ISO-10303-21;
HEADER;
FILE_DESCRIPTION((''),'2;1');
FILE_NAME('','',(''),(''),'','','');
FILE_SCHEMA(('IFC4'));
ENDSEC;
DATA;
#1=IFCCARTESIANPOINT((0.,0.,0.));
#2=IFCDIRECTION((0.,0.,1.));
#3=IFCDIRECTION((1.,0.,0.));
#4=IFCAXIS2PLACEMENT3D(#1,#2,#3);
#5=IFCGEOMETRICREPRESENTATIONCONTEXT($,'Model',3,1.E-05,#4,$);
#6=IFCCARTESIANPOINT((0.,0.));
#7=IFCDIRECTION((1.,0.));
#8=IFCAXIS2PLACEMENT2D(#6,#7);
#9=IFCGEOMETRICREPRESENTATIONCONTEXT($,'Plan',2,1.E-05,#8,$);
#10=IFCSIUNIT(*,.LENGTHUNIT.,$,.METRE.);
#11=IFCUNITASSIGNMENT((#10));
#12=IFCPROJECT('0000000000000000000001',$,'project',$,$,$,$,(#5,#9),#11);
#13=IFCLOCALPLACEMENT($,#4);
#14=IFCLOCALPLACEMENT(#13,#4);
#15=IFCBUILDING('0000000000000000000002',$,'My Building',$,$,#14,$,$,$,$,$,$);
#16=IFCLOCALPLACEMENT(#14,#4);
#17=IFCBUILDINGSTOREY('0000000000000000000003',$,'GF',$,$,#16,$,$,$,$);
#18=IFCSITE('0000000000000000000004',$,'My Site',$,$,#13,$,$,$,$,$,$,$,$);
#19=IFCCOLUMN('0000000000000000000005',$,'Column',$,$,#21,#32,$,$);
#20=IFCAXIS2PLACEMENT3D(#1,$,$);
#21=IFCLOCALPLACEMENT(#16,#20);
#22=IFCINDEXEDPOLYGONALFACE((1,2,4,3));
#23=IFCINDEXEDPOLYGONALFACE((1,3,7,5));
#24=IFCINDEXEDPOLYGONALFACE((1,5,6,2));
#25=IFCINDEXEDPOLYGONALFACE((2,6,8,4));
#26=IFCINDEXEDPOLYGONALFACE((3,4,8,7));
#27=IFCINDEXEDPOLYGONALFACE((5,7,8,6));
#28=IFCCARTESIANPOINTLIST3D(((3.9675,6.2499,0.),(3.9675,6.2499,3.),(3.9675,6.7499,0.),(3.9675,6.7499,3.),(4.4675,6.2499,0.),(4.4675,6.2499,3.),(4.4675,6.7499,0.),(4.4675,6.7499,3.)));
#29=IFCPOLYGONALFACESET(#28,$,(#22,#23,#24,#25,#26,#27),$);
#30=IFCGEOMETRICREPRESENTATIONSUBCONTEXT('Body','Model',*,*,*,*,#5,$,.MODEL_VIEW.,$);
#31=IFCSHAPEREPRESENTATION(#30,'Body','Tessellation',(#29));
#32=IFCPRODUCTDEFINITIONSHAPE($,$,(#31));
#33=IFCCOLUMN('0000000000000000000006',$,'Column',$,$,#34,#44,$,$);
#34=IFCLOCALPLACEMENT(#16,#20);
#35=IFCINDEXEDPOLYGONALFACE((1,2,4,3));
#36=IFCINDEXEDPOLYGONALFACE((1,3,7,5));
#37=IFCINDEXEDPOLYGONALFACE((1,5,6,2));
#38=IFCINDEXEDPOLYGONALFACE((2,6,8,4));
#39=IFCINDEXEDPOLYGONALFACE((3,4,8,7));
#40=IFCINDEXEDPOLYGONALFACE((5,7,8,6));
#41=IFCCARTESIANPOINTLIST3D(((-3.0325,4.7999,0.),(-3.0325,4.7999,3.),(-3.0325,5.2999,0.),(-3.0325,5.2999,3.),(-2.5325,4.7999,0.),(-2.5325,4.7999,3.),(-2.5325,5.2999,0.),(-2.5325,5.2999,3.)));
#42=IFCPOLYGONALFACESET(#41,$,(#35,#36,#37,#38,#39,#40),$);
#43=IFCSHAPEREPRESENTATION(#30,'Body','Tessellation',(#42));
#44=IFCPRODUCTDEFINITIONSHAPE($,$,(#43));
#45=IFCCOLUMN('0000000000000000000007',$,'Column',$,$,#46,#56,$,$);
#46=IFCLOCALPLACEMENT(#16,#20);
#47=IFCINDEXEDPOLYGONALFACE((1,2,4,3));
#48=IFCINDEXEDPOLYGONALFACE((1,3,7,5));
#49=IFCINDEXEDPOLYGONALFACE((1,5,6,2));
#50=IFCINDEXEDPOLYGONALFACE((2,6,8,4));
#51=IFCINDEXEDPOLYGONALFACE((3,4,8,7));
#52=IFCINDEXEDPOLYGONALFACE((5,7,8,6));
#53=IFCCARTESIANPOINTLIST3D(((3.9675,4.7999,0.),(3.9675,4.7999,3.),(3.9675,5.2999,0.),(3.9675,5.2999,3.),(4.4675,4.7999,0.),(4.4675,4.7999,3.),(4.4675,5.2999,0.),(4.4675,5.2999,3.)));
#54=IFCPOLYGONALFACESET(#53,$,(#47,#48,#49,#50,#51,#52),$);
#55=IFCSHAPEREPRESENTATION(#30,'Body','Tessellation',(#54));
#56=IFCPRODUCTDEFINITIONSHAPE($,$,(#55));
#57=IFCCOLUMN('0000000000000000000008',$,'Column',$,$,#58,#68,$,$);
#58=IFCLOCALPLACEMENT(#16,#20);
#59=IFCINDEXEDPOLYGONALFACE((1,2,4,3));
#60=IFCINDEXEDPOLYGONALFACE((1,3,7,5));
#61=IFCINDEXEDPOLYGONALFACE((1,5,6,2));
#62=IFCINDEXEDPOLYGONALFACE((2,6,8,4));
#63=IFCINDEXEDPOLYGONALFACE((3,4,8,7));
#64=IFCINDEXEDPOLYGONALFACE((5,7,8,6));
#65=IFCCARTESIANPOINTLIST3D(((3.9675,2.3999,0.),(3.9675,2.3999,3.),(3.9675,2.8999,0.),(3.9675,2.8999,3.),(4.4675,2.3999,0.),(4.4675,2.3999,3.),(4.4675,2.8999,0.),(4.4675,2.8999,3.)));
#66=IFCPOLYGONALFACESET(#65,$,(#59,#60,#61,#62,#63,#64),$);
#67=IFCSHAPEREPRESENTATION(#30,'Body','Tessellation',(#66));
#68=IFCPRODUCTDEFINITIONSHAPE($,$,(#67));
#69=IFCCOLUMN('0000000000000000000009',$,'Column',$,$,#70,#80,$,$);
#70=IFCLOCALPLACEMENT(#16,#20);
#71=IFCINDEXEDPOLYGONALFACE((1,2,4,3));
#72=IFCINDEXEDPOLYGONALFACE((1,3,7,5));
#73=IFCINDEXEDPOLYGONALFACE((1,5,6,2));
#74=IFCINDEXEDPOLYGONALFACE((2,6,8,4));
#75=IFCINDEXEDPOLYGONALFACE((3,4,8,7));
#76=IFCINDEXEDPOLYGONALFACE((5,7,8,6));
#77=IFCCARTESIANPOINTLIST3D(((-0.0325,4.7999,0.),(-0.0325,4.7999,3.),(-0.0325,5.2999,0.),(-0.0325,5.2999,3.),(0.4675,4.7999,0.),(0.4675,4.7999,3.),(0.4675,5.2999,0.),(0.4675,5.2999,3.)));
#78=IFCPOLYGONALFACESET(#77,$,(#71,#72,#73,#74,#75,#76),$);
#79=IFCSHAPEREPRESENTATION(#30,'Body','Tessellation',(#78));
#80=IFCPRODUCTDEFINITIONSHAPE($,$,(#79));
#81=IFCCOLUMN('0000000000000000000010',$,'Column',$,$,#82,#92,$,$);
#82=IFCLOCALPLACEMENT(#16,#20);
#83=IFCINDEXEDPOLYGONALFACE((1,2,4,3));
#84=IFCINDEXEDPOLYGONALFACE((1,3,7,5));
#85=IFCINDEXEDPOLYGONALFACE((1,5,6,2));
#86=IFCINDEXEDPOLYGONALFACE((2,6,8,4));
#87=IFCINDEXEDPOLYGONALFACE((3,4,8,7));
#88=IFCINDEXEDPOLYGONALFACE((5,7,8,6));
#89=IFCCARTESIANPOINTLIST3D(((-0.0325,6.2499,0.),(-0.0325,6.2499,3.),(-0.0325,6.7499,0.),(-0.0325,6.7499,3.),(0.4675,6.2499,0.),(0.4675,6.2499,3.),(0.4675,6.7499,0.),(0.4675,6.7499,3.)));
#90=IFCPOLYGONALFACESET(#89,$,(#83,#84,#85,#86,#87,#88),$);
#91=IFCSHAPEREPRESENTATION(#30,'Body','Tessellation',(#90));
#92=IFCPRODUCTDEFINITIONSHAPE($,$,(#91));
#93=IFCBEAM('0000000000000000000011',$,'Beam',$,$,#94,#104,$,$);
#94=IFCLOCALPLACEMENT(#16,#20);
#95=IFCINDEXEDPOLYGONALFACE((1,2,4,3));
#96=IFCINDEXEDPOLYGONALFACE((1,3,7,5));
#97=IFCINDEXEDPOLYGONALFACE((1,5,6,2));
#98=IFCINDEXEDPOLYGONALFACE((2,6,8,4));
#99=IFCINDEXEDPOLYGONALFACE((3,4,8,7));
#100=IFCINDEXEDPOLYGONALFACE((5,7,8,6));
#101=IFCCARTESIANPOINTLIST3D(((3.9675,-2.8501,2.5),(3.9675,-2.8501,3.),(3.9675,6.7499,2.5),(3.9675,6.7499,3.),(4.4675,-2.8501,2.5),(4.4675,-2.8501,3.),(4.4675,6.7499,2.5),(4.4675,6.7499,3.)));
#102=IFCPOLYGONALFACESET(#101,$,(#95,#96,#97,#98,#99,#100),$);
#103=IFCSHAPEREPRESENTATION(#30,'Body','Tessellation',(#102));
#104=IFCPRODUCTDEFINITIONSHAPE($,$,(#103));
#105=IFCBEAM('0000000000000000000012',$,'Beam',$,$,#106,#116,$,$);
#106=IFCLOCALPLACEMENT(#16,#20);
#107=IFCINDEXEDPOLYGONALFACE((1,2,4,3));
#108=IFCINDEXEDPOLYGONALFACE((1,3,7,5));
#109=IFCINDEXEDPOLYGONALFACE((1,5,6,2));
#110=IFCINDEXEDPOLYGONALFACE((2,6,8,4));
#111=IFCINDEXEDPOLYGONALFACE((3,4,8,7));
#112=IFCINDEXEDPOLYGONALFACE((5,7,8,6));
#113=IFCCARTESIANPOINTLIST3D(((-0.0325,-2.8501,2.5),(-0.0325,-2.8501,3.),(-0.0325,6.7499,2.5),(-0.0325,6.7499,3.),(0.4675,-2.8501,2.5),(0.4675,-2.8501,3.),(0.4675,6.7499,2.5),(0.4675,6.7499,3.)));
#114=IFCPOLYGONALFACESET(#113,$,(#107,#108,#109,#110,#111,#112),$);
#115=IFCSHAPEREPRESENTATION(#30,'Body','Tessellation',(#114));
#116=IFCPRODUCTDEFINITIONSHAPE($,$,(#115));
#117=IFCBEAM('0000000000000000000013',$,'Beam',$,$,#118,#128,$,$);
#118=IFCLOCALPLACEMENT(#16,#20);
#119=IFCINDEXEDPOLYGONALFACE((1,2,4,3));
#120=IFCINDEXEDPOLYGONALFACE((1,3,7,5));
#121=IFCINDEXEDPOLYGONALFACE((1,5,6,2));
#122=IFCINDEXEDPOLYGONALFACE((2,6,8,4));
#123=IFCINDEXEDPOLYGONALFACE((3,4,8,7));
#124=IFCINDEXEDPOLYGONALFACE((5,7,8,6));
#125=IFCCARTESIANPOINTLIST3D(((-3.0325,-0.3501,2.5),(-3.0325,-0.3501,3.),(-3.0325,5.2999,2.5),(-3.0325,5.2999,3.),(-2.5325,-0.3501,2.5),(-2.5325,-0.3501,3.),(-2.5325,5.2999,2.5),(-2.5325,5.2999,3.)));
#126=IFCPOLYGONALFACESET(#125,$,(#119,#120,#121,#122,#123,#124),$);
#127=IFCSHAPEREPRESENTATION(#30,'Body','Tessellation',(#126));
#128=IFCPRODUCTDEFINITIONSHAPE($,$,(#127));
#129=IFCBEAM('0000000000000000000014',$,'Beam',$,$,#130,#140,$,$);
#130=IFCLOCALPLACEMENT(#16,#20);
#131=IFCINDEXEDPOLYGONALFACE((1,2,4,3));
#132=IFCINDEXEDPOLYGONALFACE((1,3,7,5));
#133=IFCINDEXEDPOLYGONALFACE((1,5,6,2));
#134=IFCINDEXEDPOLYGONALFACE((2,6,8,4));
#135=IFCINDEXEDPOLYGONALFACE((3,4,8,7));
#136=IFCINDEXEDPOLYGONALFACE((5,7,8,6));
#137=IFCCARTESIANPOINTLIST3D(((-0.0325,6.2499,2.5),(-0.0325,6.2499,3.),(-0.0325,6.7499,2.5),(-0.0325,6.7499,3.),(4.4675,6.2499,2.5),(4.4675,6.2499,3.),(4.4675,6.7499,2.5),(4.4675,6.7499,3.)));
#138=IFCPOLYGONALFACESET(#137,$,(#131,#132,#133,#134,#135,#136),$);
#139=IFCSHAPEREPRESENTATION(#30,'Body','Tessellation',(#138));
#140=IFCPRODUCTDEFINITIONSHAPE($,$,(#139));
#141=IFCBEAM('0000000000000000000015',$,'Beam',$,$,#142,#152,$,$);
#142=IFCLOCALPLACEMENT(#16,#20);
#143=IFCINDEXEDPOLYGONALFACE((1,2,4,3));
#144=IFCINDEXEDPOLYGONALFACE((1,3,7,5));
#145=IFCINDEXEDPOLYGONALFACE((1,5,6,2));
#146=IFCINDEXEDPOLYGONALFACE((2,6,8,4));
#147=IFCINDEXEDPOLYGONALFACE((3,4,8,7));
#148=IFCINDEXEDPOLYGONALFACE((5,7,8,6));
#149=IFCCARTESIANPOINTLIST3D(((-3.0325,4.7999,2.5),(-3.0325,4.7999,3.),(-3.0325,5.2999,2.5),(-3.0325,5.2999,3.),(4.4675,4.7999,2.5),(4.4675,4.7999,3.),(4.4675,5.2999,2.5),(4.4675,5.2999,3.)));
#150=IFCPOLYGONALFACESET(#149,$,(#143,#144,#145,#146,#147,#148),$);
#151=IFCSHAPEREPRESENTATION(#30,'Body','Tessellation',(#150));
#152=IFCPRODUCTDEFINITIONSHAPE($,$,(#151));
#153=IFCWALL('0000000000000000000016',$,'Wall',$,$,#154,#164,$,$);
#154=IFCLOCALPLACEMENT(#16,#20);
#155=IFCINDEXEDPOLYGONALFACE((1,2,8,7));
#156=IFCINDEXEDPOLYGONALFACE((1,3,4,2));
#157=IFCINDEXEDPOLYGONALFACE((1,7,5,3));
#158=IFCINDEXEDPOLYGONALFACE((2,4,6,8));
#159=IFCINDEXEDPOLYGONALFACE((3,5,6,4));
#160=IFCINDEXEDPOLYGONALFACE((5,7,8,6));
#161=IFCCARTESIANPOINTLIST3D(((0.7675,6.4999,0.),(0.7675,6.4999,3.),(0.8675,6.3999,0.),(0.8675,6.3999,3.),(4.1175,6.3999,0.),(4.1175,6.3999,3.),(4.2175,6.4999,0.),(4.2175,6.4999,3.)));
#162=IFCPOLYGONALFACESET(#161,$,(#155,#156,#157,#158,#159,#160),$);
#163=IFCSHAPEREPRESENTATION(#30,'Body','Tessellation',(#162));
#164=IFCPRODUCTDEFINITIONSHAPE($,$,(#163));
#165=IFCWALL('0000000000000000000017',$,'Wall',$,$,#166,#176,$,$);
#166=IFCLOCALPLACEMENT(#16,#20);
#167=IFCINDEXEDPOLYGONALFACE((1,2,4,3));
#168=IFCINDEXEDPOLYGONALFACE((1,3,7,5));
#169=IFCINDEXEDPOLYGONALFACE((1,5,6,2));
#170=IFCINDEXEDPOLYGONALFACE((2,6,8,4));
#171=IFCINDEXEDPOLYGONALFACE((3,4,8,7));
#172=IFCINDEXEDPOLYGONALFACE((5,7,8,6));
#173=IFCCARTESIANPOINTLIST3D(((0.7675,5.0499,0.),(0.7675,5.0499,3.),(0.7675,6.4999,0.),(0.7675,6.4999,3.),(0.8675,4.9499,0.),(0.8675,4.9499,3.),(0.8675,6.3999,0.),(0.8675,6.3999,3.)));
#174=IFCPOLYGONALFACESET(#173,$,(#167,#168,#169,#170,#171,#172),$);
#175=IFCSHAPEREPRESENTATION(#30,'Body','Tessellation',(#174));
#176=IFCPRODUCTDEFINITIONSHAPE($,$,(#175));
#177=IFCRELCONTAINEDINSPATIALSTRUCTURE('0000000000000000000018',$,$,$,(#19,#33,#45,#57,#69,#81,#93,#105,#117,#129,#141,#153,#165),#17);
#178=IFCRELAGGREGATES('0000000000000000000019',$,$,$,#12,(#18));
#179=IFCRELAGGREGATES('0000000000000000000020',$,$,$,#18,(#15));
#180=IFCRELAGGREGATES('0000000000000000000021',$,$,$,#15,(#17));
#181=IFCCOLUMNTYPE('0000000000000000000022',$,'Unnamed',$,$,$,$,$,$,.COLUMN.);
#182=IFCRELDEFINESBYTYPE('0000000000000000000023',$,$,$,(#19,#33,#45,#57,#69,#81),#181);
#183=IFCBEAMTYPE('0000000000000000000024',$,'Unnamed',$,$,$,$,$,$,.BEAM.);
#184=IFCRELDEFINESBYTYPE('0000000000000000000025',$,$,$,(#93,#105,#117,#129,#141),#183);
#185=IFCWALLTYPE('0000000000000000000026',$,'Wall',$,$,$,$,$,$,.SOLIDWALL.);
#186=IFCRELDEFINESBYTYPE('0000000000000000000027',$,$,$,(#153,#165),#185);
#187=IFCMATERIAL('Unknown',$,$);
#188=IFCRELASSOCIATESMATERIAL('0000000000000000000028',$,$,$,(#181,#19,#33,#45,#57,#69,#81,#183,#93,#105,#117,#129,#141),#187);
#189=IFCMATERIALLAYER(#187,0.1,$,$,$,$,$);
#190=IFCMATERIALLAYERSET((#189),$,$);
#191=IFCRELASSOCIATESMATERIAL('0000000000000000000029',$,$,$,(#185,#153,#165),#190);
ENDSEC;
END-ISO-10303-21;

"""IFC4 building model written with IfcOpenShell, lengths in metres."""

from ifc_helpers import new_model, si_unit, frame, origin_with_axes, origin_2d_with_axis, place, context, subcontext, project, spatial, line, indexed_curve, rectangle, outline, extrude, material, layer, layer_set, layer_usage, material_profile, profile_set, profile_usage, type_object, element, save


model = new_model("IFC4")

# Units and contexts
model_context = context("Model", 3, precision=1e-05, world=origin_with_axes())
plan_context = context("Plan", 2, precision=1e-05, world=origin_2d_with_axis())
body_context_1 = subcontext(model_context, "Body", "Model", "MODEL_VIEW")
ifc_project = project(units=[si_unit("LENGTHUNIT", "METRE")], contexts=[model_context, plan_context])

# Site, building, storey
site_placement = place(None, origin_with_axes())
site = spatial("IfcSite", under=ifc_project, at=site_placement, Name="My Site")
building_placement = place(site_placement, origin_with_axes())
building = spatial("IfcBuilding", under=site, at=building_placement, Name="My Building")
storey_placement = place(building_placement, origin_with_axes())
storey = spatial("IfcBuildingStorey", under=building, at=storey_placement, Name="GF")

# Columns
ifc_material_1 = material(Name="Unknown")
ifc_material_profile_1 = material_profile(ifc_material_1, rectangle(XDim=0.5, YDim=0.5))
ifc_profile_set_1 = profile_set([ifc_material_profile_1])
ifc_profile_usage_1 = profile_usage(ifc_profile_set_1, cardinal=5)
column_type = type_object("IfcColumnType", Name="Unnamed", PredefinedType="COLUMN", material=ifc_profile_set_1)
column_1_placement = place(storey_placement, frame((4.2175, 6.4999, 0.0), z_axis=(0.0, 0.0, 1.0), x_axis=(1.0, 0.0, 0.0)))
element("IfcColumn", 1, at=column_1_placement, inside=storey, type_object=column_type, material=ifc_profile_usage_1, Name="Column", context=body_context_1, shape_type="SweptSolid", body=[
    extrude(rectangle(XDim=0.5, YDim=0.5), origin_with_axes(), (0.0, 0.0, 1.0), 3.0),
])
ifc_profile_usage_2 = profile_usage(ifc_profile_set_1, cardinal=5)
column_2_placement = place(storey_placement, frame((-2.7825, 5.0499, 0.0), z_axis=(0.0, 0.0, 1.0), x_axis=(1.0, 0.0, 0.0)))
element("IfcColumn", 2, at=column_2_placement, inside=storey, type_object=column_type, material=ifc_profile_usage_2, Name="Column", context=body_context_1, shape_type="SweptSolid", body=[
    extrude(rectangle(XDim=0.5, YDim=0.5), origin_with_axes(), (0.0, 0.0, 1.0), 3.0),
])
ifc_profile_usage_3 = profile_usage(ifc_profile_set_1, cardinal=5)
column_3_placement = place(storey_placement, frame((4.2175, 5.0499, 0.0), z_axis=(0.0, 0.0, 1.0), x_axis=(1.0, 0.0, 0.0)))
element("IfcColumn", 3, at=column_3_placement, inside=storey, type_object=column_type, material=ifc_profile_usage_3, Name="Column", context=body_context_1, shape_type="SweptSolid", body=[
    extrude(rectangle(XDim=0.5, YDim=0.5), origin_with_axes(), (0.0, 0.0, 1.0), 3.0),
])
ifc_profile_usage_4 = profile_usage(ifc_profile_set_1, cardinal=5)
column_4_placement = place(storey_placement, frame((4.2175, 2.6499, 0.0), z_axis=(0.0, 0.0, 1.0), x_axis=(1.0, 0.0, 0.0)))
element("IfcColumn", 4, at=column_4_placement, inside=storey, type_object=column_type, material=ifc_profile_usage_4, Name="Column", context=body_context_1, shape_type="SweptSolid", body=[
    extrude(rectangle(XDim=0.5, YDim=0.5), origin_with_axes(), (0.0, 0.0, 1.0), 3.0),
])
ifc_profile_usage_5 = profile_usage(ifc_profile_set_1, cardinal=5)
column_5_placement = place(storey_placement, frame((0.2175, 5.0499, 0.0), z_axis=(0.0, 0.0, 1.0), x_axis=(1.0, 0.0, 0.0)))
element("IfcColumn", 5, at=column_5_placement, inside=storey, type_object=column_type, material=ifc_profile_usage_5, Name="Column", context=body_context_1, shape_type="SweptSolid", body=[
    extrude(rectangle(XDim=0.5, YDim=0.5), origin_with_axes(), (0.0, 0.0, 1.0), 3.0),
])
ifc_profile_usage_6 = profile_usage(ifc_profile_set_1, cardinal=5)
column_6_placement = place(storey_placement, frame((0.2175, 6.4999, 0.0), z_axis=(0.0, 0.0, 1.0), x_axis=(1.0, 0.0, 0.0)))
element("IfcColumn", 6, at=column_6_placement, inside=storey, type_object=column_type, material=ifc_profile_usage_6, Name="Column", context=body_context_1, shape_type="SweptSolid", body=[
    extrude(rectangle(XDim=0.5, YDim=0.5), origin_with_axes(), (0.0, 0.0, 1.0), 3.0),
])

# Beams
ifc_material_profile_2 = material_profile(ifc_material_1, rectangle(XDim=0.5, YDim=0.5))
ifc_profile_set_2 = profile_set([ifc_material_profile_2])
ifc_profile_usage_7 = profile_usage(ifc_profile_set_2, cardinal=7)
beam_type = type_object("IfcBeamType", Name="Unnamed", PredefinedType="BEAM", material=ifc_profile_set_2)
beam_1_placement = place(storey_placement, frame((4.4675, 6.7499, 3.0), z_axis=(0.0, -1.0, 0.0), x_axis=(1.0, 0.0, 0.0)))
element("IfcBeam", 7, at=beam_1_placement, inside=storey, type_object=beam_type, material=ifc_profile_usage_7, Name="Beam", context=body_context_1, shape_type="SweptSolid", body=[
    extrude(rectangle(XDim=0.5, YDim=0.5), frame((-0.25, -0.25, 0.0), z_axis=(0.0, 0.0, 1.0), x_axis=(1.0, 0.0, 0.0)), (0.0, 0.0, 1.0), 9.6),
])
ifc_profile_usage_8 = profile_usage(ifc_profile_set_2, cardinal=7)
beam_2_placement = place(storey_placement, frame((0.4675, 6.7499, 3.0), z_axis=(0.0, -1.0, 0.0), x_axis=(1.0, 0.0, 0.0)))
element("IfcBeam", 8, at=beam_2_placement, inside=storey, type_object=beam_type, material=ifc_profile_usage_8, Name="Beam", context=body_context_1, shape_type="SweptSolid", body=[
    extrude(rectangle(XDim=0.5, YDim=0.5), frame((-0.25, -0.25, 0.0), z_axis=(0.0, 0.0, 1.0), x_axis=(1.0, 0.0, 0.0)), (0.0, 0.0, 1.0), 9.6),
])
ifc_profile_usage_9 = profile_usage(ifc_profile_set_2, cardinal=7)
beam_3_placement = place(storey_placement, frame((-2.5325, 5.2999, 3.0), z_axis=(0.0, -1.0, 0.0), x_axis=(1.0, 0.0, 0.0)))
element("IfcBeam", 9, at=beam_3_placement, inside=storey, type_object=beam_type, material=ifc_profile_usage_9, Name="Beam", context=body_context_1, shape_type="SweptSolid", body=[
    extrude(rectangle(XDim=0.5, YDim=0.5), frame((-0.25, -0.25, 0.0), z_axis=(0.0, 0.0, 1.0), x_axis=(1.0, 0.0, 0.0)), (0.0, 0.0, 1.0), 5.65),
])
ifc_profile_usage_10 = profile_usage(ifc_profile_set_2, cardinal=7)
beam_4_placement = place(storey_placement, frame((4.4675, 6.2499, 3.0), z_axis=(-1.0, 0.0, 0.0), x_axis=(0.0, -1.0, 0.0)))
element("IfcBeam", 10, at=beam_4_placement, inside=storey, type_object=beam_type, material=ifc_profile_usage_10, Name="Beam", context=body_context_1, shape_type="SweptSolid", body=[
    extrude(rectangle(XDim=0.5, YDim=0.5), frame((-0.25, -0.25, 0.0), z_axis=(0.0, 0.0, 1.0), x_axis=(1.0, 0.0, 0.0)), (0.0, 0.0, 1.0), 4.5),
])
ifc_profile_usage_11 = profile_usage(ifc_profile_set_2, cardinal=7)
beam_5_placement = place(storey_placement, frame((4.4675, 4.7999, 3.0), z_axis=(-1.0, 0.0, 0.0), x_axis=(0.0, -1.0, 0.0)))
element("IfcBeam", 11, at=beam_5_placement, inside=storey, type_object=beam_type, material=ifc_profile_usage_11, Name="Beam", context=body_context_1, shape_type="SweptSolid", body=[
    extrude(rectangle(XDim=0.5, YDim=0.5), frame((-0.25, -0.25, 0.0), z_axis=(0.0, 0.0, 1.0), x_axis=(1.0, 0.0, 0.0)), (0.0, 0.0, 1.0), 7.5),
])

# Walls
ifc_layer_1 = layer(ifc_material_1, 0.1)
ifc_layer_set_1 = layer_set([ifc_layer_1])
ifc_layer_usage_1 = layer_usage(ifc_layer_set_1, "AXIS2", "POSITIVE", 0.0)
wall_type = type_object("IfcWallType", Name="Wall", PredefinedType="SOLIDWALL", material=ifc_layer_set_1)
wall_1_placement = place(storey_placement, frame((4.2175, 6.4999, 0.0), z_axis=(0.0, 0.0, 1.0), x_axis=(-1.0, 0.0, 0.0)))
element("IfcWall", 12, at=wall_1_placement, inside=storey, type_object=wall_type, material=ifc_layer_usage_1, Name="Wall", context=body_context_1, shape_type="SweptSolid", body=[
    extrude(outline(indexed_curve([(0.0, 0.0), (0.1, 0.1), (3.35, 0.1), (3.45, 0.0)], segments=[line(1, 2, 3, 4, 1)])), origin_with_axes(), (0.0, 0.0, 1.0), 3.0),
])
ifc_layer_usage_2 = layer_usage(ifc_layer_set_1, "AXIS2", "POSITIVE", 0.0)
wall_2_placement = place(storey_placement, frame((0.7675, 6.4999, 0.0), z_axis=(0.0, 0.0, 1.0), x_axis=(0.0, -1.0, 0.0)))
element("IfcWall", 13, at=wall_2_placement, inside=storey, type_object=wall_type, material=ifc_layer_usage_2, Name="Wall", context=body_context_1, shape_type="SweptSolid", body=[
    extrude(outline(indexed_curve([(0.0, 0.0), (0.1, 0.1), (1.55, 0.1), (1.45, 0.0)], segments=[line(1, 2, 3, 4, 1)])), origin_with_axes(), (0.0, 0.0, 1.0), 3.0),
])

save(model, "model.ifc")
